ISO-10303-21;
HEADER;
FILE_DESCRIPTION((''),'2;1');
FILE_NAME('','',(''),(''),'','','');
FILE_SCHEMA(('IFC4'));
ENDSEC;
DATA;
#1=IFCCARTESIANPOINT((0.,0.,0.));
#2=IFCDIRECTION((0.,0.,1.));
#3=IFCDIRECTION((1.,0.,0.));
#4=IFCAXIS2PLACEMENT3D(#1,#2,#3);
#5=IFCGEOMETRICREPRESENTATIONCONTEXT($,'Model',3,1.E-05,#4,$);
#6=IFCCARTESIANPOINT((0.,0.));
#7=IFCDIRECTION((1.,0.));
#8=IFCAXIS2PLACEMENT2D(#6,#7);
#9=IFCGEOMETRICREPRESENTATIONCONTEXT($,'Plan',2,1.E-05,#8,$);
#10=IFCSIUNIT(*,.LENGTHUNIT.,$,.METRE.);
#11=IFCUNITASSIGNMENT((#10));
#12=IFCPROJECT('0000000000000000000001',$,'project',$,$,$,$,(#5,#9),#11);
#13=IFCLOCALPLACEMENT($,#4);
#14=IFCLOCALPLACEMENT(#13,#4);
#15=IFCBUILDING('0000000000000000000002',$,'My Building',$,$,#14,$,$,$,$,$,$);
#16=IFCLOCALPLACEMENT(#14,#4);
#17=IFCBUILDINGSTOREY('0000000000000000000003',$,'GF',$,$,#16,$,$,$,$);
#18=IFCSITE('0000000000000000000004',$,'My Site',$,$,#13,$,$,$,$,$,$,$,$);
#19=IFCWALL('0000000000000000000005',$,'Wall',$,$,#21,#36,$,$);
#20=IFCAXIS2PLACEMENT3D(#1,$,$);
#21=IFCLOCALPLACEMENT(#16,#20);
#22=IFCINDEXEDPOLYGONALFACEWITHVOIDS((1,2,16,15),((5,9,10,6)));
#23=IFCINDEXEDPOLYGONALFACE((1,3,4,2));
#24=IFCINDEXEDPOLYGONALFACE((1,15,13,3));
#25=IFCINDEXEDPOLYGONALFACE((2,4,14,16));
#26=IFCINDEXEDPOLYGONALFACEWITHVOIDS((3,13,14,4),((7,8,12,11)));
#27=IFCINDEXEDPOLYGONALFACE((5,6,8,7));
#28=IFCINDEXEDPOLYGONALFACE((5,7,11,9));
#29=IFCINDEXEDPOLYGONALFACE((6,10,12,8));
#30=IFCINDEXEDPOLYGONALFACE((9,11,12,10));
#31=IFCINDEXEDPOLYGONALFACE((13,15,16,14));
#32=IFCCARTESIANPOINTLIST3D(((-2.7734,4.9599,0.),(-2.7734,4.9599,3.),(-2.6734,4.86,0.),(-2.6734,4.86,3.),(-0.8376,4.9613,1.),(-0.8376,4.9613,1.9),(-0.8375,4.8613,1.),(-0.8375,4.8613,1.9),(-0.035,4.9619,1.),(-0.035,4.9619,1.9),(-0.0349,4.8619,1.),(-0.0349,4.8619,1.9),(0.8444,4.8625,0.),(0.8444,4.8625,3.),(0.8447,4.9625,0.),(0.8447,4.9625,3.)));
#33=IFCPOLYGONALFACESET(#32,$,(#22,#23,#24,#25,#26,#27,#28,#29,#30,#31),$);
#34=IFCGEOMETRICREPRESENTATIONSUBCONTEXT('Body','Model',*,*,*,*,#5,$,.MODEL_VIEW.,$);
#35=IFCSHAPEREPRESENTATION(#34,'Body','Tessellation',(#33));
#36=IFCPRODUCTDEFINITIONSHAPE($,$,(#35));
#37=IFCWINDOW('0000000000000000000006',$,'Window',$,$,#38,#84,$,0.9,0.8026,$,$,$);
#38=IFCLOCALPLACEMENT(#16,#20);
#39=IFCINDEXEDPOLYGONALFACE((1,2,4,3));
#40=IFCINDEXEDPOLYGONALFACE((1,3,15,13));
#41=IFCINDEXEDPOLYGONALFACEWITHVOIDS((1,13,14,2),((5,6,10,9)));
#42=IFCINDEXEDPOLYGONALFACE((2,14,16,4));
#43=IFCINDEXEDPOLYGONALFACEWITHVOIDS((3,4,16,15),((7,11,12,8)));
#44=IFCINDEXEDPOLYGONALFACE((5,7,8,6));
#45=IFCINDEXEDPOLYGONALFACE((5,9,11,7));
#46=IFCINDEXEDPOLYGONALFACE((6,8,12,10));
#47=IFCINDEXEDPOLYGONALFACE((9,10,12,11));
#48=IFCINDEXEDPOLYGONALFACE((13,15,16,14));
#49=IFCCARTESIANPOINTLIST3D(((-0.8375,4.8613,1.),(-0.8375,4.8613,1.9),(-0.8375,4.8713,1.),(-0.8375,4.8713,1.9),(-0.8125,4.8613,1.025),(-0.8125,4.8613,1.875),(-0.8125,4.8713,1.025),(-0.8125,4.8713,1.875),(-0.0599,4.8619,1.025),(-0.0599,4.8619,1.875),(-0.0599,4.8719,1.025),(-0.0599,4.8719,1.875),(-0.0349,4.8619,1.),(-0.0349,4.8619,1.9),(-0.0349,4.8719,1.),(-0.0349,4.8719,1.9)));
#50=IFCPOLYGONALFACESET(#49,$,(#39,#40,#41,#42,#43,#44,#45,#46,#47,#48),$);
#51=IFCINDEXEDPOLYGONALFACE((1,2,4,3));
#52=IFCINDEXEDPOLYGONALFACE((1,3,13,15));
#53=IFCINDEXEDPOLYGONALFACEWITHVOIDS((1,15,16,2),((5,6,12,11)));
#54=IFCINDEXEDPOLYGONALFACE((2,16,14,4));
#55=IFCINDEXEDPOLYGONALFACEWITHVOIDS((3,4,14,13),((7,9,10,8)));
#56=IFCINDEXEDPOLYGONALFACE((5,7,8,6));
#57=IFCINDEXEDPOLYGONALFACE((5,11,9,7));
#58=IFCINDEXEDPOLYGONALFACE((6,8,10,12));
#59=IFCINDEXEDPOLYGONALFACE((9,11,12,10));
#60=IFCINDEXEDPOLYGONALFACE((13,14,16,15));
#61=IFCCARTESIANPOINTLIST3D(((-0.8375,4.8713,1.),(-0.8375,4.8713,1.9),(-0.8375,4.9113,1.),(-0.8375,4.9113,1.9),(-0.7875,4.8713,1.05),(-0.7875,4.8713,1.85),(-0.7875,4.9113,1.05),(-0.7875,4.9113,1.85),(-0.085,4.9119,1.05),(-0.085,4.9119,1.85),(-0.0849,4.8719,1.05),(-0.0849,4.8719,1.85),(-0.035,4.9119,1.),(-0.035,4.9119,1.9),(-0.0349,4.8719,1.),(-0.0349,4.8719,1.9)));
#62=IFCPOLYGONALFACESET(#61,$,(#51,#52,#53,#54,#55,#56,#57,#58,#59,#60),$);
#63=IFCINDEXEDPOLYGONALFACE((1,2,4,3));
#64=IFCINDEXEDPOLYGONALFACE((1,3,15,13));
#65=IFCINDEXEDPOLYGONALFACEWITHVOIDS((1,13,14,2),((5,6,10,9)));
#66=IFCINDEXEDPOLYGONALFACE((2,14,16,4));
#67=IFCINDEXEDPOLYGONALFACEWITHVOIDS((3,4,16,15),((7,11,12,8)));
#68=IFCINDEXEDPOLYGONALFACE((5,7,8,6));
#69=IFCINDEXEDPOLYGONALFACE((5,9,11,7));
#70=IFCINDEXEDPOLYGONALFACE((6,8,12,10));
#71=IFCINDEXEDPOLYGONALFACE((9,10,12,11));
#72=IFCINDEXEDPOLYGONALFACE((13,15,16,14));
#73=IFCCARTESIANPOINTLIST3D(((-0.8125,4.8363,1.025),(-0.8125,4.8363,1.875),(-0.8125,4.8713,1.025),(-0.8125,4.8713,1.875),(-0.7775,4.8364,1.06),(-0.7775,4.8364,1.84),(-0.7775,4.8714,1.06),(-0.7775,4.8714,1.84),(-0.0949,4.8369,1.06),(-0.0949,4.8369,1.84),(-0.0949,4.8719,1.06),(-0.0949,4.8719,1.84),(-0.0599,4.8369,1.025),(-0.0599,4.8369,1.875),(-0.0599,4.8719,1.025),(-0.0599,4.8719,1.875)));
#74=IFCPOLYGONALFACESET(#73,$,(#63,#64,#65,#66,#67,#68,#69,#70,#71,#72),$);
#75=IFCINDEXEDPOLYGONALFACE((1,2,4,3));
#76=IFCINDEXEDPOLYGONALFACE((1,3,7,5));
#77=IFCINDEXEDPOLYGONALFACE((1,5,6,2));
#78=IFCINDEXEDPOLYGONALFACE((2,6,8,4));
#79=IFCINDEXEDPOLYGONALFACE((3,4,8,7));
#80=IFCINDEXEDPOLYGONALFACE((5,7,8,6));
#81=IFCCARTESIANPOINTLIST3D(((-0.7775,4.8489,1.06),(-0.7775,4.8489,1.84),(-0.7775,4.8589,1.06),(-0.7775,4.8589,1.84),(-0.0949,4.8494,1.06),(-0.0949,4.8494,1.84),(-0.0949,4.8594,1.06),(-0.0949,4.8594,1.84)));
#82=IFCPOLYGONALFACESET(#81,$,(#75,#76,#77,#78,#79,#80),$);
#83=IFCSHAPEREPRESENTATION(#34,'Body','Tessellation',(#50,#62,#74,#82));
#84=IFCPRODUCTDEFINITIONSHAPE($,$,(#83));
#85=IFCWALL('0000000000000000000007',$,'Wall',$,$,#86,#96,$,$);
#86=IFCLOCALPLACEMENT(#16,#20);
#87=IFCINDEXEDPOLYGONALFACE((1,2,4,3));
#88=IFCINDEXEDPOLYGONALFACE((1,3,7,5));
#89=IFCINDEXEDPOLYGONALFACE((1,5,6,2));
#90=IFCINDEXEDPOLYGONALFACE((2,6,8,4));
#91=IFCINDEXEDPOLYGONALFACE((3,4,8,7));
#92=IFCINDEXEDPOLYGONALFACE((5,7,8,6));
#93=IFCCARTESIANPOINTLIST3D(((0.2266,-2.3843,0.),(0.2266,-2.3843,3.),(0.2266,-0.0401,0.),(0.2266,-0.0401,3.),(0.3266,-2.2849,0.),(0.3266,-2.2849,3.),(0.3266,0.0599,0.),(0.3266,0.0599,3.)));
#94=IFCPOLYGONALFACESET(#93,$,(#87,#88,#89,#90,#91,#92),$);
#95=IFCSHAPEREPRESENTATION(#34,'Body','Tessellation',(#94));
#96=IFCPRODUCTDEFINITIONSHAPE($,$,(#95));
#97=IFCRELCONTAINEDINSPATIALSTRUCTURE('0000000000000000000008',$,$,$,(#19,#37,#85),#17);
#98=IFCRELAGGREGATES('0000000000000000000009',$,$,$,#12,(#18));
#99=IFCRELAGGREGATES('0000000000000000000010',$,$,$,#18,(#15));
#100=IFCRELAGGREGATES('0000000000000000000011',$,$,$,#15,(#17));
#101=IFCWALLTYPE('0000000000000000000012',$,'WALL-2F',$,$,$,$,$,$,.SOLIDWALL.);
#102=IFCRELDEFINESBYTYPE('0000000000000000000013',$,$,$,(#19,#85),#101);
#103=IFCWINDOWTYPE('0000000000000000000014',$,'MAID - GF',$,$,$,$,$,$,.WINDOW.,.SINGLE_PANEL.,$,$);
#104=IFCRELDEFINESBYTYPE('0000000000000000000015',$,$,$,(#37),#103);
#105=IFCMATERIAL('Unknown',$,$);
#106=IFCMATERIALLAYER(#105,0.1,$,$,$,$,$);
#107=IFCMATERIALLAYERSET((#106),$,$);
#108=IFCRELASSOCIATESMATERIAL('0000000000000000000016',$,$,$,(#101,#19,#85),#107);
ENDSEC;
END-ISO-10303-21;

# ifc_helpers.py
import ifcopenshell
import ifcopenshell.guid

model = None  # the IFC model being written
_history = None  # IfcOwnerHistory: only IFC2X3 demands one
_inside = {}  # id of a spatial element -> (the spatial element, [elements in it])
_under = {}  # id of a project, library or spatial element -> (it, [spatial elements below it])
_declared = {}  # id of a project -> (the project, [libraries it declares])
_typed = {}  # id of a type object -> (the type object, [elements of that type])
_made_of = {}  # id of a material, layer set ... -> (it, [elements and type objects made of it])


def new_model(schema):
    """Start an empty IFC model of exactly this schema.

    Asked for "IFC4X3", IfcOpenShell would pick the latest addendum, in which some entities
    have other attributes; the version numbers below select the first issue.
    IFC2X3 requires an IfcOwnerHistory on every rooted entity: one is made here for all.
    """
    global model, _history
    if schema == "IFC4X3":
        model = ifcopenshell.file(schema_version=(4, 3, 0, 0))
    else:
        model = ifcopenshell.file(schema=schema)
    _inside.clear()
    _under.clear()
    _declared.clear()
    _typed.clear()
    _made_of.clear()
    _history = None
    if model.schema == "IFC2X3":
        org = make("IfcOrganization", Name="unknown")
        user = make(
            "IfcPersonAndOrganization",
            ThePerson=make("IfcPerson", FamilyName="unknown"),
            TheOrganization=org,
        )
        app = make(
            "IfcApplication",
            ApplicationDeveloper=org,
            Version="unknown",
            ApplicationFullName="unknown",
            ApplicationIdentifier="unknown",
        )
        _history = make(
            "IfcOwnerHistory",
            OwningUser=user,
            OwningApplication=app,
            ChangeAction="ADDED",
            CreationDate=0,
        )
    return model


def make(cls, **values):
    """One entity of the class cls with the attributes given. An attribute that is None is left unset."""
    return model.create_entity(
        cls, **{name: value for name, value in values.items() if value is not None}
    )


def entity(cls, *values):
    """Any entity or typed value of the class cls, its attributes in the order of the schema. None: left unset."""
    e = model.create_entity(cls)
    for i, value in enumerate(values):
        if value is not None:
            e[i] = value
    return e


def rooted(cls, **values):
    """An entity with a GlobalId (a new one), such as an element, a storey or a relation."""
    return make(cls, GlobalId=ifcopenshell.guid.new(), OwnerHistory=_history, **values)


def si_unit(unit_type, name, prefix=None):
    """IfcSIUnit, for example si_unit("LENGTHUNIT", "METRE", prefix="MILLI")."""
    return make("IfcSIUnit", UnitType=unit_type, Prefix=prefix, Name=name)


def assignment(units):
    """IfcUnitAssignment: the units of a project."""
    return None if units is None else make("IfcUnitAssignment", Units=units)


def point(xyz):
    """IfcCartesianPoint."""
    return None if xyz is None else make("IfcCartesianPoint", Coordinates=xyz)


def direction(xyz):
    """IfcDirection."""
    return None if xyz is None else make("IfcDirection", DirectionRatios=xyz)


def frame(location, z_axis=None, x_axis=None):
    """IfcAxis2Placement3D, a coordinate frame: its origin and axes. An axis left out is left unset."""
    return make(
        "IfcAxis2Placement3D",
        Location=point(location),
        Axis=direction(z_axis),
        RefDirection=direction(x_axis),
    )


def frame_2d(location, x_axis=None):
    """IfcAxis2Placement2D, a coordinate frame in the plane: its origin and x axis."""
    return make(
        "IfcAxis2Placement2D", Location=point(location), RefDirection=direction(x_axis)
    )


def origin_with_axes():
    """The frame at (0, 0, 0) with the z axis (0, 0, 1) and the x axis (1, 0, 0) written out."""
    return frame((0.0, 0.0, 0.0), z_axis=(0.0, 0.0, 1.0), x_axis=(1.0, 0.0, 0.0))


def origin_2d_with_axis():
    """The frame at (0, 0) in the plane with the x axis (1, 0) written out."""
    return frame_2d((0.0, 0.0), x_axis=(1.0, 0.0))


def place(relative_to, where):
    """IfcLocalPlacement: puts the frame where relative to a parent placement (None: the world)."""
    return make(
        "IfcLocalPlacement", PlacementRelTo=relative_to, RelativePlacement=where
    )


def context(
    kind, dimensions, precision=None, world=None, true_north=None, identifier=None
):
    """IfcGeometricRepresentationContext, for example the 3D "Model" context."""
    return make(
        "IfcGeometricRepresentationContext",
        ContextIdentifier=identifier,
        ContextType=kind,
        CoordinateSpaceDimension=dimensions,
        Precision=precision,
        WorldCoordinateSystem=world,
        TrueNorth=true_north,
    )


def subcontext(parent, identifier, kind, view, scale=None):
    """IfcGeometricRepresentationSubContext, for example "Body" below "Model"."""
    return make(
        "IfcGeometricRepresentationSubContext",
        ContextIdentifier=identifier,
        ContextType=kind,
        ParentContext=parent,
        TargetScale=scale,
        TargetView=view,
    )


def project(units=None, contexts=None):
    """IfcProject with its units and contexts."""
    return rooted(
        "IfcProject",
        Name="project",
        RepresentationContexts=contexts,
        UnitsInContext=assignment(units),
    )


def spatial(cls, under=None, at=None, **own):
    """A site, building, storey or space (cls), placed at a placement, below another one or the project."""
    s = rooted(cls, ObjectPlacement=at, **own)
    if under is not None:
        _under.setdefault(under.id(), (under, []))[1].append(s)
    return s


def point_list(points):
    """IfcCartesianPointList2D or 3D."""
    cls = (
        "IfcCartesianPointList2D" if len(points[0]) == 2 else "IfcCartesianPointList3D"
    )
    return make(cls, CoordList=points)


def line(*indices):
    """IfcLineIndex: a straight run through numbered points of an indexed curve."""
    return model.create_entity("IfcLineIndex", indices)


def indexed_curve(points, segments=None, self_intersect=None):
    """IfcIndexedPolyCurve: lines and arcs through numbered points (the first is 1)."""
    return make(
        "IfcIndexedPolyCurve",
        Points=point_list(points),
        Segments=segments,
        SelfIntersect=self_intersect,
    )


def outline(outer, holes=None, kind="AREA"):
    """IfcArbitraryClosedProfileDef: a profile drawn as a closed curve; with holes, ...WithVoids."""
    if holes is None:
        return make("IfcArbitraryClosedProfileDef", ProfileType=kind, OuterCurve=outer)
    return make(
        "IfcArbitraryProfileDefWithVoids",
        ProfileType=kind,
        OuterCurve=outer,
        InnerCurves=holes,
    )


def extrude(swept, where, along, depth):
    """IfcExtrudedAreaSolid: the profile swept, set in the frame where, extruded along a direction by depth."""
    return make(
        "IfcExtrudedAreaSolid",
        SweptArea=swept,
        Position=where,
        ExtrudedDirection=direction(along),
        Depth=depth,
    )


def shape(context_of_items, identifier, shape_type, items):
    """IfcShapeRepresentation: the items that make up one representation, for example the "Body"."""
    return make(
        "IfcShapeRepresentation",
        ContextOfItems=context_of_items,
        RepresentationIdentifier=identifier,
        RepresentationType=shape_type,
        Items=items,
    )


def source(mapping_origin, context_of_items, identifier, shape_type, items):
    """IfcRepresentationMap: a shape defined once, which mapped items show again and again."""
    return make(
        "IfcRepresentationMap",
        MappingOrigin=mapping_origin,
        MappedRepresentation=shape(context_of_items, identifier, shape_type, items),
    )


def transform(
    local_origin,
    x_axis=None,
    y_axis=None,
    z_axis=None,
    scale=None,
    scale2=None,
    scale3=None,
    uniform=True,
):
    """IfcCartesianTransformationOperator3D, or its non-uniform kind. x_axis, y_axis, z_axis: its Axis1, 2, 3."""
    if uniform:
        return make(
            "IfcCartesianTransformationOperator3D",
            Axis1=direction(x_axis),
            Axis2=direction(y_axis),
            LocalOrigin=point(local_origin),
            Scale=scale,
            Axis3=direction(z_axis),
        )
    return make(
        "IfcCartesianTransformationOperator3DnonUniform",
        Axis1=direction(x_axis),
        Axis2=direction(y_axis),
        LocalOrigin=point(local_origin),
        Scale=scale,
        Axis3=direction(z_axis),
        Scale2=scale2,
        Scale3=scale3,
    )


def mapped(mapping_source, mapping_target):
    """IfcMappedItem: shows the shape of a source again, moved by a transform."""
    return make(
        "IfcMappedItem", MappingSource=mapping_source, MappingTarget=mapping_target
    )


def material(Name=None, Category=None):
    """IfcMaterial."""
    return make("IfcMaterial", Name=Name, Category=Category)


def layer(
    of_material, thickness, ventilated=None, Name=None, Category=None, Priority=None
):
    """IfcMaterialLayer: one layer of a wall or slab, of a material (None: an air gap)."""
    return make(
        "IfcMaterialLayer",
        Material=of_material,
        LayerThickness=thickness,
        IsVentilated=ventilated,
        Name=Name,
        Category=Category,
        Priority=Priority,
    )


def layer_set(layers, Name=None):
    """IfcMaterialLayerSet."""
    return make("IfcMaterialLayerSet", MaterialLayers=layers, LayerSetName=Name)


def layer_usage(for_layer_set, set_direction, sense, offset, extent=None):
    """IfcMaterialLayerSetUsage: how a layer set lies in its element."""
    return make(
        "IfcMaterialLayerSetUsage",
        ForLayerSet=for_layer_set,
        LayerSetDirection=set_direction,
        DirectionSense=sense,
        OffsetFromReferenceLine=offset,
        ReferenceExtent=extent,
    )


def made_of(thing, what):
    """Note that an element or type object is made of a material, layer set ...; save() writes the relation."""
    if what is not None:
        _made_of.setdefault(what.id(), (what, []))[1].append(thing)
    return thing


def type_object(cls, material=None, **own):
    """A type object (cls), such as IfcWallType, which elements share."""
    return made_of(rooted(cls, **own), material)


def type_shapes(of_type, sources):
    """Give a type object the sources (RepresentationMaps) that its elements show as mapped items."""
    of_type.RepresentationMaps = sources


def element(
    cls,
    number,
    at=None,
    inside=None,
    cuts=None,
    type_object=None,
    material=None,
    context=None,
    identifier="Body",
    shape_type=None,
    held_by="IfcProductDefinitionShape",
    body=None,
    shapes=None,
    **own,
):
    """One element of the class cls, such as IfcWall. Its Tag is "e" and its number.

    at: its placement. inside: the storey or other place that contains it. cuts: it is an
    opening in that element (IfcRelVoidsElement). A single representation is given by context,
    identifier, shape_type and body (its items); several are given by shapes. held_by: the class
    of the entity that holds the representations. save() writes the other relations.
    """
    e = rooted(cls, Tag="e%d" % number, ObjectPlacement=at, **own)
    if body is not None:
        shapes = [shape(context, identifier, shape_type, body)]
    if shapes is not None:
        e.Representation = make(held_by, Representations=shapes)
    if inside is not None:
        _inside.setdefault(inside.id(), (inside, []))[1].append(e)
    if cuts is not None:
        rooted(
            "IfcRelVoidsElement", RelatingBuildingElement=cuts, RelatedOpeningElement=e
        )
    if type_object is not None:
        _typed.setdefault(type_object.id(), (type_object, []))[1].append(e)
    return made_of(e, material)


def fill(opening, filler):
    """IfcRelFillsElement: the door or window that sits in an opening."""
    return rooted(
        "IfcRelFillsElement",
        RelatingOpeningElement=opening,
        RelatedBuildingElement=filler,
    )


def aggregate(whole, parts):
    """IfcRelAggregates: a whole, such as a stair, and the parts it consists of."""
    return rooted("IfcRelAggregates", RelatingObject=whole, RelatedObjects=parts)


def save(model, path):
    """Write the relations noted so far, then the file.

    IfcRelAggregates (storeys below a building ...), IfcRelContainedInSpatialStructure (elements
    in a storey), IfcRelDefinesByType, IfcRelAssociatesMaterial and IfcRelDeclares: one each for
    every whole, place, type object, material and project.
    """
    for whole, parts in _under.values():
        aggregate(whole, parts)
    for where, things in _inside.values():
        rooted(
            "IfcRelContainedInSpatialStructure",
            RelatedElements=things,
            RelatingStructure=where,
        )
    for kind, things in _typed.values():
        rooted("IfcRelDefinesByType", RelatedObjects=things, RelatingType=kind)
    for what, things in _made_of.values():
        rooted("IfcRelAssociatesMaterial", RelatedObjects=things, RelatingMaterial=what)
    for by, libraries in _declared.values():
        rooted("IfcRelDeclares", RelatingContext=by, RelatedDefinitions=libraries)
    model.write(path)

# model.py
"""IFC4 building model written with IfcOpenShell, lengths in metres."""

from ifc_helpers import new_model, entity, si_unit, frame, origin_with_axes, origin_2d_with_axis, place, context, subcontext, project, spatial, line, indexed_curve, outline, extrude, shape, source, transform, mapped, material, layer, layer_set, layer_usage, type_object, type_shapes, element, fill, save


model = new_model("IFC4")

# Units and contexts
model_context = context("Model", 3, precision=1e-05, world=origin_with_axes())
plan_context = context("Plan", 2, precision=1e-05, world=origin_2d_with_axis())
body_context_1 = subcontext(model_context, "Body", "Model", "MODEL_VIEW")
body_context_2 = subcontext(plan_context, "Body", "Plan", "PLAN_VIEW")
ifc_project = project(units=[si_unit("LENGTHUNIT", "METRE")], contexts=[model_context, plan_context])

# Site, building, storey
site_placement = place(None, origin_with_axes())
site = spatial("IfcSite", under=ifc_project, at=site_placement, Name="My Site")
building_placement = place(site_placement, origin_with_axes())
building = spatial("IfcBuilding", under=site, at=building_placement, Name="My Building")
storey_placement = place(building_placement, origin_with_axes())
storey = spatial("IfcBuildingStorey", under=building, at=storey_placement, Name="GF")

# Shared definitions
ifc_material = material(Name="Unknown")

# Shared definitions
ifc_layer_1 = layer(ifc_material, 0.1)
ifc_layer_set_1 = layer_set([ifc_layer_1])
wall_type_1 = type_object("IfcWallType", Name="WALL-2F", PredefinedType="SOLIDWALL", material=ifc_layer_set_1)

# Wall, opening, window
ifc_layer_usage_1 = layer_usage(ifc_layer_set_1, "AXIS2", "POSITIVE", 0.0)
wall_1_placement = place(storey_placement, frame((-2.7734, 4.8599, 0.0), z_axis=(0.0, 0.0, 1.0), x_axis=(1.0, 0.000731, 0.0)))
wall_1 = element("IfcWall", 1, at=wall_1_placement, inside=storey, type_object=wall_type_1, material=ifc_layer_usage_1, Name="Wall", context=body_context_1, shape_type="SweptSolid", body=[
    extrude(outline(indexed_curve([(0.1, 0.0), (0.0001, 0.1), (3.6181, 0.1), (3.6178, 0.0)], segments=[line(1, 2, 3, 4, 1)])), origin_with_axes(), (0.0, 0.0, 1.0), 3.0),
])
shared_shape_1 = source(origin_with_axes(), body_context_1, "Body", "SweptSolid", [
    extrude(outline(indexed_curve([(0.0, 0.0), (0.8026, 0.0), (0.8026, 0.9), (0.0, 0.9)], segments=[line(1, 2, 3, 4, 1)])), frame((0.0, -0.6, 0.0), z_axis=(0.0, -1.0, 0.0), x_axis=(1.0, 0.0, 0.0)), (0.0, 0.0, -1.0), 1.2),
])
opening_1_placement = place(wall_1_placement, frame((2.7385, 0.1, 1.0), z_axis=(0.0, 0.0, 1.0), x_axis=(-1.0, 0.0, 0.0)))
opening_1 = element("IfcOpeningElement", 2, at=opening_1_placement, cuts=wall_1, PredefinedType="OPENING", context=body_context_1, shape_type="MappedRepresentation", body=[
    mapped(shared_shape_1, transform((0.0, 0.0, 0.0), x_axis=(1.0, 0.0, 0.0), y_axis=(0.0, 1.0, 0.0), z_axis=(0.0, 0.0, 1.0), scale=1.0)),
])
window_type_1 = type_object("IfcWindowType", Name="MAID - GF", PartitioningType="SINGLE_PANEL", PredefinedType="WINDOW")
shared_shape_2 = source(origin_with_axes(), body_context_1, "Body", "SweptSolid", [
    extrude(outline(indexed_curve([(0.0, 0.0), (0.8026, 0.0), (0.8026, 0.9), (0.0, 0.9)], segments=[line(1, 2, 3, 4, 1)]), holes=[indexed_curve([(0.025, 0.025), (0.7776, 0.025), (0.7776, 0.875), (0.025, 0.875)], segments=[line(1, 2, 3, 4, 1)])]), frame((0.0, 0.09, 0.0), z_axis=(0.0, -1.0, 0.0), x_axis=(1.0, 0.0, 0.0)), (0.0, 0.0, -1.0), 0.01),
    extrude(outline(indexed_curve([(0.0, 0.0), (0.8026, 0.0), (0.8026, 0.9), (0.0, 0.9)], segments=[line(1, 2, 3, 4, 1)]), holes=[indexed_curve([(0.05, 0.05), (0.7526, 0.05), (0.7526, 0.85), (0.05, 0.85)], segments=[line(1, 2, 3, 4, 1)])]), frame((0.0, 0.05, 0.0), z_axis=(0.0, -1.0, 0.0), x_axis=(1.0, 0.0, 0.0)), (0.0, 0.0, -1.0), 0.04),
    extrude(outline(indexed_curve([(0.0, 0.0), (0.7526, 0.0), (0.7526, 0.85), (0.0, 0.85)], segments=[line(1, 2, 3, 4, 1)]), holes=[indexed_curve([(0.035, 0.035), (0.7176, 0.035), (0.7176, 0.815), (0.035, 0.815)], segments=[line(1, 2, 3, 4, 1)])]), frame((0.025, 0.09, 0.025), z_axis=(0.0, -1.0, 0.0), x_axis=(1.0, 0.0, 0.0)), (0.0, 0.0, -1.0), 0.035),
    extrude(outline(indexed_curve([(0.035, 0.035), (0.7176, 0.035), (0.7176, 0.815), (0.035, 0.815)], segments=[line(1, 2, 3, 4, 1)])), frame((0.025, 0.1025, 0.025), z_axis=(0.0, -1.0, 0.0), x_axis=(1.0, 0.0, 0.0)), (0.0, 0.0, -1.0), 0.01),
])
shared_shape_3 = source(origin_with_axes(), body_context_2, "Body", "Curve2D", [
    entity("IfcIndexedPolyCurve", entity("IfcCartesianPointList2D", [[0.05, 0.05], [0.7526, 0.05]])),
    entity("IfcIndexedPolyCurve", entity("IfcCartesianPointList2D", [[0.0, 0.1], [0.025, 0.1], [0.025, 0.09], [0.05, 0.09], [0.05, 0.05], [0.0, 0.05]]), [entity("IfcLineIndex", [1, 2, 3, 4, 5, 6, 1])]),
    entity("IfcIndexedPolyCurve", entity("IfcCartesianPointList2D", [[0.8026, 0.1], [0.7776, 0.1], [0.7776, 0.09], [0.7526, 0.09], [0.7526, 0.05], [0.8026, 0.05]]), [entity("IfcLineIndex", [1, 2, 3, 4, 5, 6, 1])]),
    entity("IfcIndexedPolyCurve", entity("IfcCartesianPointList2D", [[0.025, 0.09], [0.06, 0.09], [0.06, 0.125], [0.025, 0.125]]), [entity("IfcLineIndex", [1, 2, 3, 4, 1])]),
    entity("IfcIndexedPolyCurve", entity("IfcCartesianPointList2D", [[0.7776, 0.09], [0.7426, 0.09], [0.7426, 0.125], [0.7776, 0.125]]), [entity("IfcLineIndex", [1, 2, 3, 4, 1])]),
    entity("IfcIndexedPolyCurve", entity("IfcCartesianPointList2D", [[0.06, 0.09], [0.7426, 0.09]])),
    entity("IfcIndexedPolyCurve", entity("IfcCartesianPointList2D", [[0.06, 0.125], [0.7426, 0.125]])),
    entity("IfcIndexedPolyCurve", entity("IfcCartesianPointList2D", [[0.06, 0.1075], [0.7426, 0.1075]])),
])
type_shapes(window_type_1, [shared_shape_2, shared_shape_3])
window_1_placement = place(opening_1_placement, frame((0.0, 0.0, 0.0), z_axis=(0.0, 0.0, 1.0), x_axis=(1.0, 0.0, 0.0)))
window_1 = element("IfcWindow", 3, at=window_1_placement, inside=storey, type_object=window_type_1, Name="Window", OverallHeight=0.9, OverallWidth=0.8026, shapes=[
    shape(body_context_1, "Body", "MappedRepresentation", [mapped(shared_shape_2, transform((0.0, 0.0, 0.0), x_axis=(1.0, 0.0, 0.0), y_axis=(0.0, 1.0, 0.0), z_axis=(0.0, 0.0, 1.0), scale=1.0))]),
    shape(body_context_2, "Body", "MappedRepresentation", [mapped(shared_shape_3, transform((0.0, 0.0, 0.0), x_axis=(1.0, 0.0, 0.0), y_axis=(0.0, 1.0, 0.0), z_axis=(0.0, 0.0, 1.0), scale=1.0))]),
])
fill(opening_1, window_1)

# Wall
ifc_layer_usage_2 = layer_usage(ifc_layer_set_1, "AXIS2", "POSITIVE", 0.0)
wall_2_placement = place(storey_placement, frame((0.2266, -0.0401, 0.0), z_axis=(0.0, 0.0, 1.0), x_axis=(0.0, -1.0, 0.0)))
element("IfcWall", 4, at=wall_2_placement, inside=storey, type_object=wall_type_1, material=ifc_layer_usage_2, Name="Wall", context=body_context_1, shape_type="SweptSolid", body=[
    extrude(outline(indexed_curve([(0.0, 0.0), (-0.1, 0.1), (2.2448, 0.1), (2.3442, 0.0)], segments=[line(1, 2, 3, 4, 1)])), origin_with_axes(), (0.0, 0.0, 1.0), 3.0),
])

save(model, "model.ifc")
